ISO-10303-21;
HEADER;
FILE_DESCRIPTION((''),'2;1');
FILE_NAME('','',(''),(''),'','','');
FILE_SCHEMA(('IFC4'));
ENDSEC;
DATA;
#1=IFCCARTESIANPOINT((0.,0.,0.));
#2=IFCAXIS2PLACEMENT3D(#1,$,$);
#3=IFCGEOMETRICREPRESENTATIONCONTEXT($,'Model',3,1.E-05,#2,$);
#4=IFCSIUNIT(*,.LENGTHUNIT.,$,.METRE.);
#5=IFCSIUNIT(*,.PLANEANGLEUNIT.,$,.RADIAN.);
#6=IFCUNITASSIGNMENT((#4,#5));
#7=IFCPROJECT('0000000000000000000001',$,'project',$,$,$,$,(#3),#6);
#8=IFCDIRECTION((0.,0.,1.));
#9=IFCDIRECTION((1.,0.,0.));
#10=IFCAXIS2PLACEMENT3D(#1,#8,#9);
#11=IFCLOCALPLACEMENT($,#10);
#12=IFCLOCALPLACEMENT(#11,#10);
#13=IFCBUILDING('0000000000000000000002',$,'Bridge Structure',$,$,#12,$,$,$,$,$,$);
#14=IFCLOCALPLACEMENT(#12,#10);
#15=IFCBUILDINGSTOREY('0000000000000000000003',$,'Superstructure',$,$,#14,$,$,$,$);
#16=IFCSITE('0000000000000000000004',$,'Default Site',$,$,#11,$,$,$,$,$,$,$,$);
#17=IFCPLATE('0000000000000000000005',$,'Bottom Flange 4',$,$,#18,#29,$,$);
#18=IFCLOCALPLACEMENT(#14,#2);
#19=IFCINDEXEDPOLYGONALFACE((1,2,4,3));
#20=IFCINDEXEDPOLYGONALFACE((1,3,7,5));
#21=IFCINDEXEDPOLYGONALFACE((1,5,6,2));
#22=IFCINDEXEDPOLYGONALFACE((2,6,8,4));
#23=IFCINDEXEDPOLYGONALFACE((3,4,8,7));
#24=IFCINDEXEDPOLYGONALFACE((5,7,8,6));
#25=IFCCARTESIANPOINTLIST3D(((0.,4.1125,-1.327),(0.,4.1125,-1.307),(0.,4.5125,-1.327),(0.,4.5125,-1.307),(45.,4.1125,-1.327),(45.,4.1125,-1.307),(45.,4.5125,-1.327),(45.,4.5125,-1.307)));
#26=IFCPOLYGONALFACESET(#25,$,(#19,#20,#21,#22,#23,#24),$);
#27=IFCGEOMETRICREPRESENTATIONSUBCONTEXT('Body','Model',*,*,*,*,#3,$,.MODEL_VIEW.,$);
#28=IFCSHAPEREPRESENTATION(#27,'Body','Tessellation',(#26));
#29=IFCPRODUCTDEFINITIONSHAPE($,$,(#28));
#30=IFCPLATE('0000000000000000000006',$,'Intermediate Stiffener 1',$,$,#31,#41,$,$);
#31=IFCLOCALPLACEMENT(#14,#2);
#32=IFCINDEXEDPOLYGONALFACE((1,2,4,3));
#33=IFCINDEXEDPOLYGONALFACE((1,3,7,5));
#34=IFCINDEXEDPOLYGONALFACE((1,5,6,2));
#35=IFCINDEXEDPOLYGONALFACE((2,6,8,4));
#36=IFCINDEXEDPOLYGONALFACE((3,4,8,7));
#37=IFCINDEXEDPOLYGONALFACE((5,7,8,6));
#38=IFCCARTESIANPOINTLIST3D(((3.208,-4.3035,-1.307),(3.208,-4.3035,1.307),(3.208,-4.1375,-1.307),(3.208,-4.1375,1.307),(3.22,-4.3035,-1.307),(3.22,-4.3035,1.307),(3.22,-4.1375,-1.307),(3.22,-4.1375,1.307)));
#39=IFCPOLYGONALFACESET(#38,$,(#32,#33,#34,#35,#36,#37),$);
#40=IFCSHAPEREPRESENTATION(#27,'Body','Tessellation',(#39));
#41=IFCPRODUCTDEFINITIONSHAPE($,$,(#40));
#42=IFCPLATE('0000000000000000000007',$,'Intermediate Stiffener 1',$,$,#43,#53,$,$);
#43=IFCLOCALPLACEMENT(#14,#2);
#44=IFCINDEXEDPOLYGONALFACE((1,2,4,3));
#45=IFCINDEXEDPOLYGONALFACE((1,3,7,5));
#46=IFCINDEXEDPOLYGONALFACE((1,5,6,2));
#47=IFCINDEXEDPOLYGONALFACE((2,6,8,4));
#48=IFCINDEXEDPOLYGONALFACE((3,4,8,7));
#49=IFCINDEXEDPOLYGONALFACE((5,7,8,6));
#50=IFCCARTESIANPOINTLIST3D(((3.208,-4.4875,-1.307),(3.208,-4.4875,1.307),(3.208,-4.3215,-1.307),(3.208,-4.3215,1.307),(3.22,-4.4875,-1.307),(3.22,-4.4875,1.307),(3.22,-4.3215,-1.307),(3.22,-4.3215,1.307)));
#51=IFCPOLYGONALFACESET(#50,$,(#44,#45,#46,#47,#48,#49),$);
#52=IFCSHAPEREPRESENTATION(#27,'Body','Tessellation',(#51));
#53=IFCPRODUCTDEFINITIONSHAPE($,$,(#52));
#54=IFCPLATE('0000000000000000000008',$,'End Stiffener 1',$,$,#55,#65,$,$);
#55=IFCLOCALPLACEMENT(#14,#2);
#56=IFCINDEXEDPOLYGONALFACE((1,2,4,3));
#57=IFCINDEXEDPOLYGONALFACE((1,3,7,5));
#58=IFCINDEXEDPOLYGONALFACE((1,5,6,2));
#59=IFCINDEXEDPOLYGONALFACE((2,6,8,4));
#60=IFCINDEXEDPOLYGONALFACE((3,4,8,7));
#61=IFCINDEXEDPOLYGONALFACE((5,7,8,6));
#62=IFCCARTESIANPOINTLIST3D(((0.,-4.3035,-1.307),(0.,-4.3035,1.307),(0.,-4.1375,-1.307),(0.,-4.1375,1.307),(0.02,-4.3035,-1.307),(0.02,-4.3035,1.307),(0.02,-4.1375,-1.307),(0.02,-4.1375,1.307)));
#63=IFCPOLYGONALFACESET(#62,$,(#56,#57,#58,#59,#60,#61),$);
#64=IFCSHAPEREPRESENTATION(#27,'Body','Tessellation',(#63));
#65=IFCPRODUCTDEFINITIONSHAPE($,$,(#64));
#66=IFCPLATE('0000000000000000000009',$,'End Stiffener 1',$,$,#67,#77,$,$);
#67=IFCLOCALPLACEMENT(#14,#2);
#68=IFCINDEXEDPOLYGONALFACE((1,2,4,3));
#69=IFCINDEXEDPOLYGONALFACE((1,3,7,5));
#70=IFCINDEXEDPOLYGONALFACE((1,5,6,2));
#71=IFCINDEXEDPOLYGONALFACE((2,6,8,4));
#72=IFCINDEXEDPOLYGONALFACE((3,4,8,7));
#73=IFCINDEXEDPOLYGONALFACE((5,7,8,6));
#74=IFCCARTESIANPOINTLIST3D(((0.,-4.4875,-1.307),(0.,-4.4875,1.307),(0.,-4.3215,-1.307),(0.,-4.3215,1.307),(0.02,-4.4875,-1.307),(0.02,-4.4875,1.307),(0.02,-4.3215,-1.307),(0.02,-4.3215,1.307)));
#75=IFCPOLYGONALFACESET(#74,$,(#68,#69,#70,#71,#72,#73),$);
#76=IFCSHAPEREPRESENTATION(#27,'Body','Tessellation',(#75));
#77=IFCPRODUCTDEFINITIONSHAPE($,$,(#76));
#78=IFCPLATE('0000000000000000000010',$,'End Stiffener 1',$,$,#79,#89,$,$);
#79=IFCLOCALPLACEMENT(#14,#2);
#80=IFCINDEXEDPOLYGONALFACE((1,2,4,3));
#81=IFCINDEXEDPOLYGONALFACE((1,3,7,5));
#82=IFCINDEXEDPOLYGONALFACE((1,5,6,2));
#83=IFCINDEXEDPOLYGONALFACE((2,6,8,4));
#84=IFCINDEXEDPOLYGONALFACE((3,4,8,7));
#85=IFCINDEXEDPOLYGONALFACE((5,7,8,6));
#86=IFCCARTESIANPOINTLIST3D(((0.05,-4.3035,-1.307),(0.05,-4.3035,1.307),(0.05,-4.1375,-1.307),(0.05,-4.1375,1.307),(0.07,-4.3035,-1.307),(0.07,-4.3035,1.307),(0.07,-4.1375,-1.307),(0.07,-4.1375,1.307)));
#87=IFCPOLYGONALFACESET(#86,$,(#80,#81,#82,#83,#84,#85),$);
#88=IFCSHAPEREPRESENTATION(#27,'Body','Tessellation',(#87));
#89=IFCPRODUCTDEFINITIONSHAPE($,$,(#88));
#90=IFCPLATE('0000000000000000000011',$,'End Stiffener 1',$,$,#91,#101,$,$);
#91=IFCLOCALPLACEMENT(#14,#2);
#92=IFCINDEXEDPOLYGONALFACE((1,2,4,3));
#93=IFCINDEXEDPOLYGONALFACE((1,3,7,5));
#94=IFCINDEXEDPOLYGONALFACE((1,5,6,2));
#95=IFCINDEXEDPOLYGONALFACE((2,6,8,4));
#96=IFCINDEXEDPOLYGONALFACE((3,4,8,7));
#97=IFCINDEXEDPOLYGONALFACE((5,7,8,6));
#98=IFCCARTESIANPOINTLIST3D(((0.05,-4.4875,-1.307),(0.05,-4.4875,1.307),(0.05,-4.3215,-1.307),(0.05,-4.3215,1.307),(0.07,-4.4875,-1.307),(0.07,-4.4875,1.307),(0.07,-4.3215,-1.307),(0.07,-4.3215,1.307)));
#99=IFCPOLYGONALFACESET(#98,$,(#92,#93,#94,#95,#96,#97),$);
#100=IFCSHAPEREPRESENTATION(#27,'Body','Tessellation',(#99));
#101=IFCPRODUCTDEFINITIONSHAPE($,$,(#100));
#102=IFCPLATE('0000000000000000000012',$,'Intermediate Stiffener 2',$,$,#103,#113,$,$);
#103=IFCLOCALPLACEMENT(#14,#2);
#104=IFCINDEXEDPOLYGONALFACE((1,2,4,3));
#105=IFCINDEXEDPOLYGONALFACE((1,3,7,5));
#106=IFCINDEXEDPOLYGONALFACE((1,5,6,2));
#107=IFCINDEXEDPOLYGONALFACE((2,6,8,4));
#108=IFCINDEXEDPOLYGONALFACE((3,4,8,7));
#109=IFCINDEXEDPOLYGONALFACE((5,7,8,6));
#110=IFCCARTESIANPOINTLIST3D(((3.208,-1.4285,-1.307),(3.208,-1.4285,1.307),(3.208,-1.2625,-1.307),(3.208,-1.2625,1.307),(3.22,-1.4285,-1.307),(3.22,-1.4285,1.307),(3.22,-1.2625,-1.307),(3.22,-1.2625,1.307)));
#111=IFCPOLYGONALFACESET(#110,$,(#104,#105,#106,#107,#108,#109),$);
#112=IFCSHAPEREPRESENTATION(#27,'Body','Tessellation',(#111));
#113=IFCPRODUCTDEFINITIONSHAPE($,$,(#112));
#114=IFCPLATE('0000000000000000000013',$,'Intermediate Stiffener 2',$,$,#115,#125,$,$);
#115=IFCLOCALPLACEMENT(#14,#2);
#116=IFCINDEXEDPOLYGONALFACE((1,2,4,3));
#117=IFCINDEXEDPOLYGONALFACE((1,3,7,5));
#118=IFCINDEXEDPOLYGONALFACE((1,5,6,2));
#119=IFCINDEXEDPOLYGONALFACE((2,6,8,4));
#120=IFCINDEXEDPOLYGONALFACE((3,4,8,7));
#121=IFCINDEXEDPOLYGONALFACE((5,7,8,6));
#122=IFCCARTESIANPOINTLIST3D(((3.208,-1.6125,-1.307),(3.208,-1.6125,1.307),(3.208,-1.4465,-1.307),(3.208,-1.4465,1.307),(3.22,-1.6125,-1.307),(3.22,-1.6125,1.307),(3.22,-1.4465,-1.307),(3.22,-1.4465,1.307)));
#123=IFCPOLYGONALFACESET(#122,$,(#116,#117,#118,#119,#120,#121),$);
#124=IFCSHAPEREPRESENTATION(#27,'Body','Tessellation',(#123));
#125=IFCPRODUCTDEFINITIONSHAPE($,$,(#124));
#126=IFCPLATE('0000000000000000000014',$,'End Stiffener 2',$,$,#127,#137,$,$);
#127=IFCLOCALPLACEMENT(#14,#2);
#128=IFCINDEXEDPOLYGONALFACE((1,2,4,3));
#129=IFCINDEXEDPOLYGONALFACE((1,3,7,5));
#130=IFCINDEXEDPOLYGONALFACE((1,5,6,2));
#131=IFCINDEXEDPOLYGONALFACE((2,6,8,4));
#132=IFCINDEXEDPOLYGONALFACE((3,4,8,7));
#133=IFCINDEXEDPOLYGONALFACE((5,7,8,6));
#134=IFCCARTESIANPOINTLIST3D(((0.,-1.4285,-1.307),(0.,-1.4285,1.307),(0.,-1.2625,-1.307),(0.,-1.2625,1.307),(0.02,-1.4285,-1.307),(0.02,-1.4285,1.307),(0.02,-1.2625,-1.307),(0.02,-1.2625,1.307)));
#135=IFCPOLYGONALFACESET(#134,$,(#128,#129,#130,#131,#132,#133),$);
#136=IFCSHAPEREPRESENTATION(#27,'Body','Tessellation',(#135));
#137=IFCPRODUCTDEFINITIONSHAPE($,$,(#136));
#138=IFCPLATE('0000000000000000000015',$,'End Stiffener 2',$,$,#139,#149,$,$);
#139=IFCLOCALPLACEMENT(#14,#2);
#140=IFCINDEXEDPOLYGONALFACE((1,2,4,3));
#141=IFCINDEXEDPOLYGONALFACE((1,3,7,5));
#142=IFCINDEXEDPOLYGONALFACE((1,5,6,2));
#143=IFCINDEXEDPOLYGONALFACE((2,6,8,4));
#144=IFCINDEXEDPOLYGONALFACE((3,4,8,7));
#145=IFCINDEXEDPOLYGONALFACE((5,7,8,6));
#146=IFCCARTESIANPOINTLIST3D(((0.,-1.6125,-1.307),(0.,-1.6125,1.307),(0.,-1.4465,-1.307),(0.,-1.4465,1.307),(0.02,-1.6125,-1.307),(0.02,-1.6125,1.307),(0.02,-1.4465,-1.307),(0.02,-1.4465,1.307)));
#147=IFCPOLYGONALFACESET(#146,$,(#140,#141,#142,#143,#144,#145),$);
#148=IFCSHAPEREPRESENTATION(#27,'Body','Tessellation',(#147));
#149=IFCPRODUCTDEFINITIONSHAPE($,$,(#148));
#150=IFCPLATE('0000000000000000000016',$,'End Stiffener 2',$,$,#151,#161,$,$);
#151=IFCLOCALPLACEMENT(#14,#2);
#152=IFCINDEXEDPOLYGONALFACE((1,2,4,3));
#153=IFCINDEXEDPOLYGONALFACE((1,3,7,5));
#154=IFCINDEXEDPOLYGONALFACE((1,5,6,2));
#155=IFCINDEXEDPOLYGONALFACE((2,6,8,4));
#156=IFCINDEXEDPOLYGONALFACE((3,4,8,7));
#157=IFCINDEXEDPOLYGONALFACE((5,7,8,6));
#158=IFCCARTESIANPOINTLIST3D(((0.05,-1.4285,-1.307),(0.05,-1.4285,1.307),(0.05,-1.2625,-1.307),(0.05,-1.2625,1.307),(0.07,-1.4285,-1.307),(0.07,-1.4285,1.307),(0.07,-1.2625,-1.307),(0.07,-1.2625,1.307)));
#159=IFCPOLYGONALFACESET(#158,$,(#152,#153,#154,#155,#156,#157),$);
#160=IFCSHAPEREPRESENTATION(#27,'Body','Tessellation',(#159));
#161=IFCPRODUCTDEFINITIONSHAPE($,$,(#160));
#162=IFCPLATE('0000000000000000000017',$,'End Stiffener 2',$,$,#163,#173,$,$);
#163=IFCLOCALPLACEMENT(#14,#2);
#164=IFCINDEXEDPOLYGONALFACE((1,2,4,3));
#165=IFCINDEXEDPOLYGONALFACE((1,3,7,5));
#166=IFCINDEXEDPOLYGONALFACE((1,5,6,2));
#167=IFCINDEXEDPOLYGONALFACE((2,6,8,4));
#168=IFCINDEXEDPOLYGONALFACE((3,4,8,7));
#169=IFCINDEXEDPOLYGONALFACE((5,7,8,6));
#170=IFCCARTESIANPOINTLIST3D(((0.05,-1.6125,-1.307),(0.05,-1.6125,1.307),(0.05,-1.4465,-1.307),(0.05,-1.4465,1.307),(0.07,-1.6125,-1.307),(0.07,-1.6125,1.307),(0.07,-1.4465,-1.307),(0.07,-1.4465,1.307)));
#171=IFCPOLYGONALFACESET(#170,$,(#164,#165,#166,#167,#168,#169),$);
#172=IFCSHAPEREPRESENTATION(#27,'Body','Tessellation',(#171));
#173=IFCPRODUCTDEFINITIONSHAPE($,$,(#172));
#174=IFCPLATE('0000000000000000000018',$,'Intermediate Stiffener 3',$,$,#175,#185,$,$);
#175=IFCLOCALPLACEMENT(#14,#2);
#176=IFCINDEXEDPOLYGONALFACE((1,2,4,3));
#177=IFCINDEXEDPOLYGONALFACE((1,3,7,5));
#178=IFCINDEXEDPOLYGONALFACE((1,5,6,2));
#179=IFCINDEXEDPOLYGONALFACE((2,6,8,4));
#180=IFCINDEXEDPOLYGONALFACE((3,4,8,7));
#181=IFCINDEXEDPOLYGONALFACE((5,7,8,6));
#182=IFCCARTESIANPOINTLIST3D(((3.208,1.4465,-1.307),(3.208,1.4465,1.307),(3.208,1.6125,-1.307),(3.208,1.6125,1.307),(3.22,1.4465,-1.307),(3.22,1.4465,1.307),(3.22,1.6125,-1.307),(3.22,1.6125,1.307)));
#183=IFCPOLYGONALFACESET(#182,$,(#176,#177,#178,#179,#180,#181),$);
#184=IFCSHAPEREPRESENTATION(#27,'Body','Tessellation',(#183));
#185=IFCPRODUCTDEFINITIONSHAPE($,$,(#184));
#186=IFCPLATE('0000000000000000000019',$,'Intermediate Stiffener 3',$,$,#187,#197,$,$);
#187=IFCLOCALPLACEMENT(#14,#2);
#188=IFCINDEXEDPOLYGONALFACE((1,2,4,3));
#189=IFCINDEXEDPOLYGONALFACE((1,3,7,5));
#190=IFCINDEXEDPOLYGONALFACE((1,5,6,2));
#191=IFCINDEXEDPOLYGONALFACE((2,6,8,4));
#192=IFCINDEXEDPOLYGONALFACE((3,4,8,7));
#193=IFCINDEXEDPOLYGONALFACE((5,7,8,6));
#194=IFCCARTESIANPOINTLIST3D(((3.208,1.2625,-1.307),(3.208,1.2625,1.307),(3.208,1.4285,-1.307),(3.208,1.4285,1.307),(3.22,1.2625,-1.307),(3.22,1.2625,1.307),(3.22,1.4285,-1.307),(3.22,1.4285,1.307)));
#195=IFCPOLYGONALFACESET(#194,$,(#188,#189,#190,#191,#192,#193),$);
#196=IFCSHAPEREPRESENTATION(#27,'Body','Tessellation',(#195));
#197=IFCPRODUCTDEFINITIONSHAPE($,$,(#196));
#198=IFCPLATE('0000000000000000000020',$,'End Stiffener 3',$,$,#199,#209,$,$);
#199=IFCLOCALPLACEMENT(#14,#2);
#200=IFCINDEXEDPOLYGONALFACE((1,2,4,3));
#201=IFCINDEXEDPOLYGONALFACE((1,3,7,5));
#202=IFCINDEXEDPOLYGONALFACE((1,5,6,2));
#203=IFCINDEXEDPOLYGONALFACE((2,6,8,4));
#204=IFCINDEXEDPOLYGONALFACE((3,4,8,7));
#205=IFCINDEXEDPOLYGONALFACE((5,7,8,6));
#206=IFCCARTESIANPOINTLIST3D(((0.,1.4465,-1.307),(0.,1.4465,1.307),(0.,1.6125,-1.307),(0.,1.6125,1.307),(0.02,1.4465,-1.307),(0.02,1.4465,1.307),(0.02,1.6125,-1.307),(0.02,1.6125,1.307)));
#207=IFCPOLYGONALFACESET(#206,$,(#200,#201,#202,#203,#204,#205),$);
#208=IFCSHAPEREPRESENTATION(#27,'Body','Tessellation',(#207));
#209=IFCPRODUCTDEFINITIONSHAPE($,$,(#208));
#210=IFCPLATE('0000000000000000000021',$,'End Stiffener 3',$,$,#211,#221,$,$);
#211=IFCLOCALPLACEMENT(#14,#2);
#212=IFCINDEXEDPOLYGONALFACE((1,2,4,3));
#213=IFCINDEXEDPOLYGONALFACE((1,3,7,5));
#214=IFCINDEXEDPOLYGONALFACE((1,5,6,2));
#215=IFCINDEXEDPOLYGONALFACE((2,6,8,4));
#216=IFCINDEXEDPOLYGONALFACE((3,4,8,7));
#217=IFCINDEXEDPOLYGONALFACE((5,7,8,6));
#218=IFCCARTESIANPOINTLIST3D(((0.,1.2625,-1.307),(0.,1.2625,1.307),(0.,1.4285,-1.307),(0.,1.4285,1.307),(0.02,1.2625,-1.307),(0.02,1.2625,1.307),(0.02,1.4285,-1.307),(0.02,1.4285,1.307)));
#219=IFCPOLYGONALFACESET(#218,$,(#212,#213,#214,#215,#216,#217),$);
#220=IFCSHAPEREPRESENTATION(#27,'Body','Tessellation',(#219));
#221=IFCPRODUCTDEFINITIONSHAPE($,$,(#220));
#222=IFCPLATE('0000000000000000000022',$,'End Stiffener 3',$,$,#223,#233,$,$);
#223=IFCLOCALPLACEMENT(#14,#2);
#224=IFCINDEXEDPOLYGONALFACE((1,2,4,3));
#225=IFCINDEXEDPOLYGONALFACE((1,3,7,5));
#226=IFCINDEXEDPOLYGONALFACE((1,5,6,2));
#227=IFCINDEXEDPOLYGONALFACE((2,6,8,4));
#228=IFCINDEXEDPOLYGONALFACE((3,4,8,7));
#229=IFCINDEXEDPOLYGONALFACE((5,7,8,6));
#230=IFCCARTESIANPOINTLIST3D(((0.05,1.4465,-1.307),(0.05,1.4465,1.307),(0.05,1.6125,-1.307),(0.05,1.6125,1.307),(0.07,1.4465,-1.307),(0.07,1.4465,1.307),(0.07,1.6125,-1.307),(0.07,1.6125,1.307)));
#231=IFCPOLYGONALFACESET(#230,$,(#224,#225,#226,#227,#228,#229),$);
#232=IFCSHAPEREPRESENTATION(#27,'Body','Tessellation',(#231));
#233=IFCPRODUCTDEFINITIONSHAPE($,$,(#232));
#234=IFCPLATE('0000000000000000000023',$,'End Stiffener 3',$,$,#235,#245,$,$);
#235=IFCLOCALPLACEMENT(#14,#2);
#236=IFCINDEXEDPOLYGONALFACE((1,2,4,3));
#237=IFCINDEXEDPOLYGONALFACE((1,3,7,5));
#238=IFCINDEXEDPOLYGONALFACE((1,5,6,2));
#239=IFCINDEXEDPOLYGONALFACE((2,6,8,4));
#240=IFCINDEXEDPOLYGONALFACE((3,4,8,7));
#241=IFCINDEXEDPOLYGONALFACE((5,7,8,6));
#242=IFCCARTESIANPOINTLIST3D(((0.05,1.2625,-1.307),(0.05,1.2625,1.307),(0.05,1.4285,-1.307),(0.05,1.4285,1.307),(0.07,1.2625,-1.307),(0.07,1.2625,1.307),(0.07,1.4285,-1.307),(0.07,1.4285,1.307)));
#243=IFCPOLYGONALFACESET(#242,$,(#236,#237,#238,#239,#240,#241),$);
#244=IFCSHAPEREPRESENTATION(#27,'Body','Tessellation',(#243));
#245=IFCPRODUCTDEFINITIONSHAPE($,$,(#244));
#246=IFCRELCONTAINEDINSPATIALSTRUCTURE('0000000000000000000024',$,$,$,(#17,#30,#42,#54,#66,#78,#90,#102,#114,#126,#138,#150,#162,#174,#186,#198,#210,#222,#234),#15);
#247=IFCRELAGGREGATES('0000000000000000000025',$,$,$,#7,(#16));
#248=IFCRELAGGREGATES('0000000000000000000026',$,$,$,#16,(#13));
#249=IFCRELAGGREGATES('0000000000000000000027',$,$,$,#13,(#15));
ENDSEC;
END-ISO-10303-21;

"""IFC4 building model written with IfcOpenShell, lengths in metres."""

from ifc_helpers import new_model, si_unit, frame, origin, origin_with_axes, origin_2d_with_axis, place, context, subcontext, project, spatial, rectangle, extrude, element, save


model = new_model("IFC4")

# Units and contexts
model_context = context("Model", 3, precision=1e-05, world=origin())
body_context = subcontext(model_context, "Body", "Model", "MODEL_VIEW")
ifc_project = project(units=[si_unit("LENGTHUNIT", "METRE"), si_unit("PLANEANGLEUNIT", "RADIAN")], contexts=[model_context])

# Site, building, storey
site_placement = place(None, origin_with_axes())
site = spatial("IfcSite", under=ifc_project, at=site_placement, Name="Default Site")
building_placement = place(site_placement, origin_with_axes())
building = spatial("IfcBuilding", under=site, at=building_placement, Name="Bridge Structure")
storey_placement = place(building_placement, origin_with_axes())
storey = spatial("IfcBuildingStorey", under=building, at=storey_placement, Name="Superstructure")

# Plates
plate_1_placement = place(storey_placement, frame((0.0, 4.3125, -1.317), z_axis=(1.0, 0.0, 0.0), x_axis=(0.0, 1.0, 0.0)))
element("IfcPlate", 1, at=plate_1_placement, inside=storey, Name="Bottom Flange 4", context=body_context, shape_type="SweptSolid", body=[
    extrude(rectangle(XDim=0.4, YDim=0.02, at=origin_2d_with_axis()), origin_with_axes(), (0.0, 0.0, 1.0), 45.0),
])
for number, where, z_axis, x_axis, name in (
    (2, (3.214, -4.2205, -1.307), (0.0, 0.0, 1.0), (1.0, 0.0, 0.0), "Intermediate Stiffener 1"),
    (3, (3.214, -4.4045, -1.307), (0.0, 0.0, 1.0), (1.0, 0.0, 0.0), "Intermediate Stiffener 1"),
):
    element("IfcPlate", number, at=place(storey_placement, frame(where, z_axis=z_axis, x_axis=x_axis)), inside=storey, Name=name, context=body_context, shape_type="SweptSolid", body=[
        extrude(rectangle(XDim=0.012, YDim=0.166, at=origin_2d_with_axis()), origin_with_axes(), (0.0, 0.0, 1.0), 2.614),
    ])
for number, where, z_axis, x_axis, name in (
    (4, (0.01, -4.2205, -1.307), (0.0, 0.0, 1.0), (1.0, 0.0, 0.0), "End Stiffener 1"),
    (5, (0.01, -4.4045, -1.307), (0.0, 0.0, 1.0), (1.0, 0.0, 0.0), "End Stiffener 1"),
    (6, (0.06, -4.2205, -1.307), (0.0, 0.0, 1.0), (1.0, 0.0, 0.0), "End Stiffener 1"),
    (7, (0.06, -4.4045, -1.307), (0.0, 0.0, 1.0), (1.0, 0.0, 0.0), "End Stiffener 1"),
):
    element("IfcPlate", number, at=place(storey_placement, frame(where, z_axis=z_axis, x_axis=x_axis)), inside=storey, Name=name, context=body_context, shape_type="SweptSolid", body=[
        extrude(rectangle(XDim=0.02, YDim=0.166, at=origin_2d_with_axis()), origin_with_axes(), (0.0, 0.0, 1.0), 2.614),
    ])
for number, where, z_axis, x_axis, name in (
    (8, (3.214, -1.3455, -1.307), (0.0, 0.0, 1.0), (1.0, 0.0, 0.0), "Intermediate Stiffener 2"),
    (9, (3.214, -1.5295, -1.307), (0.0, 0.0, 1.0), (1.0, 0.0, 0.0), "Intermediate Stiffener 2"),
):
    element("IfcPlate", number, at=place(storey_placement, frame(where, z_axis=z_axis, x_axis=x_axis)), inside=storey, Name=name, context=body_context, shape_type="SweptSolid", body=[
        extrude(rectangle(XDim=0.012, YDim=0.166, at=origin_2d_with_axis()), origin_with_axes(), (0.0, 0.0, 1.0), 2.614),
    ])
for number, where, z_axis, x_axis, name in (
    (10, (0.01, -1.3455, -1.307), (0.0, 0.0, 1.0), (1.0, 0.0, 0.0), "End Stiffener 2"),
    (11, (0.01, -1.5295, -1.307), (0.0, 0.0, 1.0), (1.0, 0.0, 0.0), "End Stiffener 2"),
    (12, (0.06, -1.3455, -1.307), (0.0, 0.0, 1.0), (1.0, 0.0, 0.0), "End Stiffener 2"),
    (13, (0.06, -1.5295, -1.307), (0.0, 0.0, 1.0), (1.0, 0.0, 0.0), "End Stiffener 2"),
):
    element("IfcPlate", number, at=place(storey_placement, frame(where, z_axis=z_axis, x_axis=x_axis)), inside=storey, Name=name, context=body_context, shape_type="SweptSolid", body=[
        extrude(rectangle(XDim=0.02, YDim=0.166, at=origin_2d_with_axis()), origin_with_axes(), (0.0, 0.0, 1.0), 2.614),
    ])
for number, where, z_axis, x_axis, name in (
    (14, (3.214, 1.5295, -1.307), (0.0, 0.0, 1.0), (1.0, 0.0, 0.0), "Intermediate Stiffener 3"),
    (15, (3.214, 1.3455, -1.307), (0.0, 0.0, 1.0), (1.0, 0.0, 0.0), "Intermediate Stiffener 3"),
):
    element("IfcPlate", number, at=place(storey_placement, frame(where, z_axis=z_axis, x_axis=x_axis)), inside=storey, Name=name, context=body_context, shape_type="SweptSolid", body=[
        extrude(rectangle(XDim=0.012, YDim=0.166, at=origin_2d_with_axis()), origin_with_axes(), (0.0, 0.0, 1.0), 2.614),
    ])
for number, where, z_axis, x_axis, name in (
    (16, (0.01, 1.5295, -1.307), (0.0, 0.0, 1.0), (1.0, 0.0, 0.0), "End Stiffener 3"),
    (17, (0.01, 1.3455, -1.307), (0.0, 0.0, 1.0), (1.0, 0.0, 0.0), "End Stiffener 3"),
    (18, (0.06, 1.5295, -1.307), (0.0, 0.0, 1.0), (1.0, 0.0, 0.0), "End Stiffener 3"),
    (19, (0.06, 1.3455, -1.307), (0.0, 0.0, 1.0), (1.0, 0.0, 0.0), "End Stiffener 3"),
):
    element("IfcPlate", number, at=place(storey_placement, frame(where, z_axis=z_axis, x_axis=x_axis)), inside=storey, Name=name, context=body_context, shape_type="SweptSolid", body=[
        extrude(rectangle(XDim=0.02, YDim=0.166, at=origin_2d_with_axis()), origin_with_axes(), (0.0, 0.0, 1.0), 2.614),
    ])

save(model, "model.ifc")
